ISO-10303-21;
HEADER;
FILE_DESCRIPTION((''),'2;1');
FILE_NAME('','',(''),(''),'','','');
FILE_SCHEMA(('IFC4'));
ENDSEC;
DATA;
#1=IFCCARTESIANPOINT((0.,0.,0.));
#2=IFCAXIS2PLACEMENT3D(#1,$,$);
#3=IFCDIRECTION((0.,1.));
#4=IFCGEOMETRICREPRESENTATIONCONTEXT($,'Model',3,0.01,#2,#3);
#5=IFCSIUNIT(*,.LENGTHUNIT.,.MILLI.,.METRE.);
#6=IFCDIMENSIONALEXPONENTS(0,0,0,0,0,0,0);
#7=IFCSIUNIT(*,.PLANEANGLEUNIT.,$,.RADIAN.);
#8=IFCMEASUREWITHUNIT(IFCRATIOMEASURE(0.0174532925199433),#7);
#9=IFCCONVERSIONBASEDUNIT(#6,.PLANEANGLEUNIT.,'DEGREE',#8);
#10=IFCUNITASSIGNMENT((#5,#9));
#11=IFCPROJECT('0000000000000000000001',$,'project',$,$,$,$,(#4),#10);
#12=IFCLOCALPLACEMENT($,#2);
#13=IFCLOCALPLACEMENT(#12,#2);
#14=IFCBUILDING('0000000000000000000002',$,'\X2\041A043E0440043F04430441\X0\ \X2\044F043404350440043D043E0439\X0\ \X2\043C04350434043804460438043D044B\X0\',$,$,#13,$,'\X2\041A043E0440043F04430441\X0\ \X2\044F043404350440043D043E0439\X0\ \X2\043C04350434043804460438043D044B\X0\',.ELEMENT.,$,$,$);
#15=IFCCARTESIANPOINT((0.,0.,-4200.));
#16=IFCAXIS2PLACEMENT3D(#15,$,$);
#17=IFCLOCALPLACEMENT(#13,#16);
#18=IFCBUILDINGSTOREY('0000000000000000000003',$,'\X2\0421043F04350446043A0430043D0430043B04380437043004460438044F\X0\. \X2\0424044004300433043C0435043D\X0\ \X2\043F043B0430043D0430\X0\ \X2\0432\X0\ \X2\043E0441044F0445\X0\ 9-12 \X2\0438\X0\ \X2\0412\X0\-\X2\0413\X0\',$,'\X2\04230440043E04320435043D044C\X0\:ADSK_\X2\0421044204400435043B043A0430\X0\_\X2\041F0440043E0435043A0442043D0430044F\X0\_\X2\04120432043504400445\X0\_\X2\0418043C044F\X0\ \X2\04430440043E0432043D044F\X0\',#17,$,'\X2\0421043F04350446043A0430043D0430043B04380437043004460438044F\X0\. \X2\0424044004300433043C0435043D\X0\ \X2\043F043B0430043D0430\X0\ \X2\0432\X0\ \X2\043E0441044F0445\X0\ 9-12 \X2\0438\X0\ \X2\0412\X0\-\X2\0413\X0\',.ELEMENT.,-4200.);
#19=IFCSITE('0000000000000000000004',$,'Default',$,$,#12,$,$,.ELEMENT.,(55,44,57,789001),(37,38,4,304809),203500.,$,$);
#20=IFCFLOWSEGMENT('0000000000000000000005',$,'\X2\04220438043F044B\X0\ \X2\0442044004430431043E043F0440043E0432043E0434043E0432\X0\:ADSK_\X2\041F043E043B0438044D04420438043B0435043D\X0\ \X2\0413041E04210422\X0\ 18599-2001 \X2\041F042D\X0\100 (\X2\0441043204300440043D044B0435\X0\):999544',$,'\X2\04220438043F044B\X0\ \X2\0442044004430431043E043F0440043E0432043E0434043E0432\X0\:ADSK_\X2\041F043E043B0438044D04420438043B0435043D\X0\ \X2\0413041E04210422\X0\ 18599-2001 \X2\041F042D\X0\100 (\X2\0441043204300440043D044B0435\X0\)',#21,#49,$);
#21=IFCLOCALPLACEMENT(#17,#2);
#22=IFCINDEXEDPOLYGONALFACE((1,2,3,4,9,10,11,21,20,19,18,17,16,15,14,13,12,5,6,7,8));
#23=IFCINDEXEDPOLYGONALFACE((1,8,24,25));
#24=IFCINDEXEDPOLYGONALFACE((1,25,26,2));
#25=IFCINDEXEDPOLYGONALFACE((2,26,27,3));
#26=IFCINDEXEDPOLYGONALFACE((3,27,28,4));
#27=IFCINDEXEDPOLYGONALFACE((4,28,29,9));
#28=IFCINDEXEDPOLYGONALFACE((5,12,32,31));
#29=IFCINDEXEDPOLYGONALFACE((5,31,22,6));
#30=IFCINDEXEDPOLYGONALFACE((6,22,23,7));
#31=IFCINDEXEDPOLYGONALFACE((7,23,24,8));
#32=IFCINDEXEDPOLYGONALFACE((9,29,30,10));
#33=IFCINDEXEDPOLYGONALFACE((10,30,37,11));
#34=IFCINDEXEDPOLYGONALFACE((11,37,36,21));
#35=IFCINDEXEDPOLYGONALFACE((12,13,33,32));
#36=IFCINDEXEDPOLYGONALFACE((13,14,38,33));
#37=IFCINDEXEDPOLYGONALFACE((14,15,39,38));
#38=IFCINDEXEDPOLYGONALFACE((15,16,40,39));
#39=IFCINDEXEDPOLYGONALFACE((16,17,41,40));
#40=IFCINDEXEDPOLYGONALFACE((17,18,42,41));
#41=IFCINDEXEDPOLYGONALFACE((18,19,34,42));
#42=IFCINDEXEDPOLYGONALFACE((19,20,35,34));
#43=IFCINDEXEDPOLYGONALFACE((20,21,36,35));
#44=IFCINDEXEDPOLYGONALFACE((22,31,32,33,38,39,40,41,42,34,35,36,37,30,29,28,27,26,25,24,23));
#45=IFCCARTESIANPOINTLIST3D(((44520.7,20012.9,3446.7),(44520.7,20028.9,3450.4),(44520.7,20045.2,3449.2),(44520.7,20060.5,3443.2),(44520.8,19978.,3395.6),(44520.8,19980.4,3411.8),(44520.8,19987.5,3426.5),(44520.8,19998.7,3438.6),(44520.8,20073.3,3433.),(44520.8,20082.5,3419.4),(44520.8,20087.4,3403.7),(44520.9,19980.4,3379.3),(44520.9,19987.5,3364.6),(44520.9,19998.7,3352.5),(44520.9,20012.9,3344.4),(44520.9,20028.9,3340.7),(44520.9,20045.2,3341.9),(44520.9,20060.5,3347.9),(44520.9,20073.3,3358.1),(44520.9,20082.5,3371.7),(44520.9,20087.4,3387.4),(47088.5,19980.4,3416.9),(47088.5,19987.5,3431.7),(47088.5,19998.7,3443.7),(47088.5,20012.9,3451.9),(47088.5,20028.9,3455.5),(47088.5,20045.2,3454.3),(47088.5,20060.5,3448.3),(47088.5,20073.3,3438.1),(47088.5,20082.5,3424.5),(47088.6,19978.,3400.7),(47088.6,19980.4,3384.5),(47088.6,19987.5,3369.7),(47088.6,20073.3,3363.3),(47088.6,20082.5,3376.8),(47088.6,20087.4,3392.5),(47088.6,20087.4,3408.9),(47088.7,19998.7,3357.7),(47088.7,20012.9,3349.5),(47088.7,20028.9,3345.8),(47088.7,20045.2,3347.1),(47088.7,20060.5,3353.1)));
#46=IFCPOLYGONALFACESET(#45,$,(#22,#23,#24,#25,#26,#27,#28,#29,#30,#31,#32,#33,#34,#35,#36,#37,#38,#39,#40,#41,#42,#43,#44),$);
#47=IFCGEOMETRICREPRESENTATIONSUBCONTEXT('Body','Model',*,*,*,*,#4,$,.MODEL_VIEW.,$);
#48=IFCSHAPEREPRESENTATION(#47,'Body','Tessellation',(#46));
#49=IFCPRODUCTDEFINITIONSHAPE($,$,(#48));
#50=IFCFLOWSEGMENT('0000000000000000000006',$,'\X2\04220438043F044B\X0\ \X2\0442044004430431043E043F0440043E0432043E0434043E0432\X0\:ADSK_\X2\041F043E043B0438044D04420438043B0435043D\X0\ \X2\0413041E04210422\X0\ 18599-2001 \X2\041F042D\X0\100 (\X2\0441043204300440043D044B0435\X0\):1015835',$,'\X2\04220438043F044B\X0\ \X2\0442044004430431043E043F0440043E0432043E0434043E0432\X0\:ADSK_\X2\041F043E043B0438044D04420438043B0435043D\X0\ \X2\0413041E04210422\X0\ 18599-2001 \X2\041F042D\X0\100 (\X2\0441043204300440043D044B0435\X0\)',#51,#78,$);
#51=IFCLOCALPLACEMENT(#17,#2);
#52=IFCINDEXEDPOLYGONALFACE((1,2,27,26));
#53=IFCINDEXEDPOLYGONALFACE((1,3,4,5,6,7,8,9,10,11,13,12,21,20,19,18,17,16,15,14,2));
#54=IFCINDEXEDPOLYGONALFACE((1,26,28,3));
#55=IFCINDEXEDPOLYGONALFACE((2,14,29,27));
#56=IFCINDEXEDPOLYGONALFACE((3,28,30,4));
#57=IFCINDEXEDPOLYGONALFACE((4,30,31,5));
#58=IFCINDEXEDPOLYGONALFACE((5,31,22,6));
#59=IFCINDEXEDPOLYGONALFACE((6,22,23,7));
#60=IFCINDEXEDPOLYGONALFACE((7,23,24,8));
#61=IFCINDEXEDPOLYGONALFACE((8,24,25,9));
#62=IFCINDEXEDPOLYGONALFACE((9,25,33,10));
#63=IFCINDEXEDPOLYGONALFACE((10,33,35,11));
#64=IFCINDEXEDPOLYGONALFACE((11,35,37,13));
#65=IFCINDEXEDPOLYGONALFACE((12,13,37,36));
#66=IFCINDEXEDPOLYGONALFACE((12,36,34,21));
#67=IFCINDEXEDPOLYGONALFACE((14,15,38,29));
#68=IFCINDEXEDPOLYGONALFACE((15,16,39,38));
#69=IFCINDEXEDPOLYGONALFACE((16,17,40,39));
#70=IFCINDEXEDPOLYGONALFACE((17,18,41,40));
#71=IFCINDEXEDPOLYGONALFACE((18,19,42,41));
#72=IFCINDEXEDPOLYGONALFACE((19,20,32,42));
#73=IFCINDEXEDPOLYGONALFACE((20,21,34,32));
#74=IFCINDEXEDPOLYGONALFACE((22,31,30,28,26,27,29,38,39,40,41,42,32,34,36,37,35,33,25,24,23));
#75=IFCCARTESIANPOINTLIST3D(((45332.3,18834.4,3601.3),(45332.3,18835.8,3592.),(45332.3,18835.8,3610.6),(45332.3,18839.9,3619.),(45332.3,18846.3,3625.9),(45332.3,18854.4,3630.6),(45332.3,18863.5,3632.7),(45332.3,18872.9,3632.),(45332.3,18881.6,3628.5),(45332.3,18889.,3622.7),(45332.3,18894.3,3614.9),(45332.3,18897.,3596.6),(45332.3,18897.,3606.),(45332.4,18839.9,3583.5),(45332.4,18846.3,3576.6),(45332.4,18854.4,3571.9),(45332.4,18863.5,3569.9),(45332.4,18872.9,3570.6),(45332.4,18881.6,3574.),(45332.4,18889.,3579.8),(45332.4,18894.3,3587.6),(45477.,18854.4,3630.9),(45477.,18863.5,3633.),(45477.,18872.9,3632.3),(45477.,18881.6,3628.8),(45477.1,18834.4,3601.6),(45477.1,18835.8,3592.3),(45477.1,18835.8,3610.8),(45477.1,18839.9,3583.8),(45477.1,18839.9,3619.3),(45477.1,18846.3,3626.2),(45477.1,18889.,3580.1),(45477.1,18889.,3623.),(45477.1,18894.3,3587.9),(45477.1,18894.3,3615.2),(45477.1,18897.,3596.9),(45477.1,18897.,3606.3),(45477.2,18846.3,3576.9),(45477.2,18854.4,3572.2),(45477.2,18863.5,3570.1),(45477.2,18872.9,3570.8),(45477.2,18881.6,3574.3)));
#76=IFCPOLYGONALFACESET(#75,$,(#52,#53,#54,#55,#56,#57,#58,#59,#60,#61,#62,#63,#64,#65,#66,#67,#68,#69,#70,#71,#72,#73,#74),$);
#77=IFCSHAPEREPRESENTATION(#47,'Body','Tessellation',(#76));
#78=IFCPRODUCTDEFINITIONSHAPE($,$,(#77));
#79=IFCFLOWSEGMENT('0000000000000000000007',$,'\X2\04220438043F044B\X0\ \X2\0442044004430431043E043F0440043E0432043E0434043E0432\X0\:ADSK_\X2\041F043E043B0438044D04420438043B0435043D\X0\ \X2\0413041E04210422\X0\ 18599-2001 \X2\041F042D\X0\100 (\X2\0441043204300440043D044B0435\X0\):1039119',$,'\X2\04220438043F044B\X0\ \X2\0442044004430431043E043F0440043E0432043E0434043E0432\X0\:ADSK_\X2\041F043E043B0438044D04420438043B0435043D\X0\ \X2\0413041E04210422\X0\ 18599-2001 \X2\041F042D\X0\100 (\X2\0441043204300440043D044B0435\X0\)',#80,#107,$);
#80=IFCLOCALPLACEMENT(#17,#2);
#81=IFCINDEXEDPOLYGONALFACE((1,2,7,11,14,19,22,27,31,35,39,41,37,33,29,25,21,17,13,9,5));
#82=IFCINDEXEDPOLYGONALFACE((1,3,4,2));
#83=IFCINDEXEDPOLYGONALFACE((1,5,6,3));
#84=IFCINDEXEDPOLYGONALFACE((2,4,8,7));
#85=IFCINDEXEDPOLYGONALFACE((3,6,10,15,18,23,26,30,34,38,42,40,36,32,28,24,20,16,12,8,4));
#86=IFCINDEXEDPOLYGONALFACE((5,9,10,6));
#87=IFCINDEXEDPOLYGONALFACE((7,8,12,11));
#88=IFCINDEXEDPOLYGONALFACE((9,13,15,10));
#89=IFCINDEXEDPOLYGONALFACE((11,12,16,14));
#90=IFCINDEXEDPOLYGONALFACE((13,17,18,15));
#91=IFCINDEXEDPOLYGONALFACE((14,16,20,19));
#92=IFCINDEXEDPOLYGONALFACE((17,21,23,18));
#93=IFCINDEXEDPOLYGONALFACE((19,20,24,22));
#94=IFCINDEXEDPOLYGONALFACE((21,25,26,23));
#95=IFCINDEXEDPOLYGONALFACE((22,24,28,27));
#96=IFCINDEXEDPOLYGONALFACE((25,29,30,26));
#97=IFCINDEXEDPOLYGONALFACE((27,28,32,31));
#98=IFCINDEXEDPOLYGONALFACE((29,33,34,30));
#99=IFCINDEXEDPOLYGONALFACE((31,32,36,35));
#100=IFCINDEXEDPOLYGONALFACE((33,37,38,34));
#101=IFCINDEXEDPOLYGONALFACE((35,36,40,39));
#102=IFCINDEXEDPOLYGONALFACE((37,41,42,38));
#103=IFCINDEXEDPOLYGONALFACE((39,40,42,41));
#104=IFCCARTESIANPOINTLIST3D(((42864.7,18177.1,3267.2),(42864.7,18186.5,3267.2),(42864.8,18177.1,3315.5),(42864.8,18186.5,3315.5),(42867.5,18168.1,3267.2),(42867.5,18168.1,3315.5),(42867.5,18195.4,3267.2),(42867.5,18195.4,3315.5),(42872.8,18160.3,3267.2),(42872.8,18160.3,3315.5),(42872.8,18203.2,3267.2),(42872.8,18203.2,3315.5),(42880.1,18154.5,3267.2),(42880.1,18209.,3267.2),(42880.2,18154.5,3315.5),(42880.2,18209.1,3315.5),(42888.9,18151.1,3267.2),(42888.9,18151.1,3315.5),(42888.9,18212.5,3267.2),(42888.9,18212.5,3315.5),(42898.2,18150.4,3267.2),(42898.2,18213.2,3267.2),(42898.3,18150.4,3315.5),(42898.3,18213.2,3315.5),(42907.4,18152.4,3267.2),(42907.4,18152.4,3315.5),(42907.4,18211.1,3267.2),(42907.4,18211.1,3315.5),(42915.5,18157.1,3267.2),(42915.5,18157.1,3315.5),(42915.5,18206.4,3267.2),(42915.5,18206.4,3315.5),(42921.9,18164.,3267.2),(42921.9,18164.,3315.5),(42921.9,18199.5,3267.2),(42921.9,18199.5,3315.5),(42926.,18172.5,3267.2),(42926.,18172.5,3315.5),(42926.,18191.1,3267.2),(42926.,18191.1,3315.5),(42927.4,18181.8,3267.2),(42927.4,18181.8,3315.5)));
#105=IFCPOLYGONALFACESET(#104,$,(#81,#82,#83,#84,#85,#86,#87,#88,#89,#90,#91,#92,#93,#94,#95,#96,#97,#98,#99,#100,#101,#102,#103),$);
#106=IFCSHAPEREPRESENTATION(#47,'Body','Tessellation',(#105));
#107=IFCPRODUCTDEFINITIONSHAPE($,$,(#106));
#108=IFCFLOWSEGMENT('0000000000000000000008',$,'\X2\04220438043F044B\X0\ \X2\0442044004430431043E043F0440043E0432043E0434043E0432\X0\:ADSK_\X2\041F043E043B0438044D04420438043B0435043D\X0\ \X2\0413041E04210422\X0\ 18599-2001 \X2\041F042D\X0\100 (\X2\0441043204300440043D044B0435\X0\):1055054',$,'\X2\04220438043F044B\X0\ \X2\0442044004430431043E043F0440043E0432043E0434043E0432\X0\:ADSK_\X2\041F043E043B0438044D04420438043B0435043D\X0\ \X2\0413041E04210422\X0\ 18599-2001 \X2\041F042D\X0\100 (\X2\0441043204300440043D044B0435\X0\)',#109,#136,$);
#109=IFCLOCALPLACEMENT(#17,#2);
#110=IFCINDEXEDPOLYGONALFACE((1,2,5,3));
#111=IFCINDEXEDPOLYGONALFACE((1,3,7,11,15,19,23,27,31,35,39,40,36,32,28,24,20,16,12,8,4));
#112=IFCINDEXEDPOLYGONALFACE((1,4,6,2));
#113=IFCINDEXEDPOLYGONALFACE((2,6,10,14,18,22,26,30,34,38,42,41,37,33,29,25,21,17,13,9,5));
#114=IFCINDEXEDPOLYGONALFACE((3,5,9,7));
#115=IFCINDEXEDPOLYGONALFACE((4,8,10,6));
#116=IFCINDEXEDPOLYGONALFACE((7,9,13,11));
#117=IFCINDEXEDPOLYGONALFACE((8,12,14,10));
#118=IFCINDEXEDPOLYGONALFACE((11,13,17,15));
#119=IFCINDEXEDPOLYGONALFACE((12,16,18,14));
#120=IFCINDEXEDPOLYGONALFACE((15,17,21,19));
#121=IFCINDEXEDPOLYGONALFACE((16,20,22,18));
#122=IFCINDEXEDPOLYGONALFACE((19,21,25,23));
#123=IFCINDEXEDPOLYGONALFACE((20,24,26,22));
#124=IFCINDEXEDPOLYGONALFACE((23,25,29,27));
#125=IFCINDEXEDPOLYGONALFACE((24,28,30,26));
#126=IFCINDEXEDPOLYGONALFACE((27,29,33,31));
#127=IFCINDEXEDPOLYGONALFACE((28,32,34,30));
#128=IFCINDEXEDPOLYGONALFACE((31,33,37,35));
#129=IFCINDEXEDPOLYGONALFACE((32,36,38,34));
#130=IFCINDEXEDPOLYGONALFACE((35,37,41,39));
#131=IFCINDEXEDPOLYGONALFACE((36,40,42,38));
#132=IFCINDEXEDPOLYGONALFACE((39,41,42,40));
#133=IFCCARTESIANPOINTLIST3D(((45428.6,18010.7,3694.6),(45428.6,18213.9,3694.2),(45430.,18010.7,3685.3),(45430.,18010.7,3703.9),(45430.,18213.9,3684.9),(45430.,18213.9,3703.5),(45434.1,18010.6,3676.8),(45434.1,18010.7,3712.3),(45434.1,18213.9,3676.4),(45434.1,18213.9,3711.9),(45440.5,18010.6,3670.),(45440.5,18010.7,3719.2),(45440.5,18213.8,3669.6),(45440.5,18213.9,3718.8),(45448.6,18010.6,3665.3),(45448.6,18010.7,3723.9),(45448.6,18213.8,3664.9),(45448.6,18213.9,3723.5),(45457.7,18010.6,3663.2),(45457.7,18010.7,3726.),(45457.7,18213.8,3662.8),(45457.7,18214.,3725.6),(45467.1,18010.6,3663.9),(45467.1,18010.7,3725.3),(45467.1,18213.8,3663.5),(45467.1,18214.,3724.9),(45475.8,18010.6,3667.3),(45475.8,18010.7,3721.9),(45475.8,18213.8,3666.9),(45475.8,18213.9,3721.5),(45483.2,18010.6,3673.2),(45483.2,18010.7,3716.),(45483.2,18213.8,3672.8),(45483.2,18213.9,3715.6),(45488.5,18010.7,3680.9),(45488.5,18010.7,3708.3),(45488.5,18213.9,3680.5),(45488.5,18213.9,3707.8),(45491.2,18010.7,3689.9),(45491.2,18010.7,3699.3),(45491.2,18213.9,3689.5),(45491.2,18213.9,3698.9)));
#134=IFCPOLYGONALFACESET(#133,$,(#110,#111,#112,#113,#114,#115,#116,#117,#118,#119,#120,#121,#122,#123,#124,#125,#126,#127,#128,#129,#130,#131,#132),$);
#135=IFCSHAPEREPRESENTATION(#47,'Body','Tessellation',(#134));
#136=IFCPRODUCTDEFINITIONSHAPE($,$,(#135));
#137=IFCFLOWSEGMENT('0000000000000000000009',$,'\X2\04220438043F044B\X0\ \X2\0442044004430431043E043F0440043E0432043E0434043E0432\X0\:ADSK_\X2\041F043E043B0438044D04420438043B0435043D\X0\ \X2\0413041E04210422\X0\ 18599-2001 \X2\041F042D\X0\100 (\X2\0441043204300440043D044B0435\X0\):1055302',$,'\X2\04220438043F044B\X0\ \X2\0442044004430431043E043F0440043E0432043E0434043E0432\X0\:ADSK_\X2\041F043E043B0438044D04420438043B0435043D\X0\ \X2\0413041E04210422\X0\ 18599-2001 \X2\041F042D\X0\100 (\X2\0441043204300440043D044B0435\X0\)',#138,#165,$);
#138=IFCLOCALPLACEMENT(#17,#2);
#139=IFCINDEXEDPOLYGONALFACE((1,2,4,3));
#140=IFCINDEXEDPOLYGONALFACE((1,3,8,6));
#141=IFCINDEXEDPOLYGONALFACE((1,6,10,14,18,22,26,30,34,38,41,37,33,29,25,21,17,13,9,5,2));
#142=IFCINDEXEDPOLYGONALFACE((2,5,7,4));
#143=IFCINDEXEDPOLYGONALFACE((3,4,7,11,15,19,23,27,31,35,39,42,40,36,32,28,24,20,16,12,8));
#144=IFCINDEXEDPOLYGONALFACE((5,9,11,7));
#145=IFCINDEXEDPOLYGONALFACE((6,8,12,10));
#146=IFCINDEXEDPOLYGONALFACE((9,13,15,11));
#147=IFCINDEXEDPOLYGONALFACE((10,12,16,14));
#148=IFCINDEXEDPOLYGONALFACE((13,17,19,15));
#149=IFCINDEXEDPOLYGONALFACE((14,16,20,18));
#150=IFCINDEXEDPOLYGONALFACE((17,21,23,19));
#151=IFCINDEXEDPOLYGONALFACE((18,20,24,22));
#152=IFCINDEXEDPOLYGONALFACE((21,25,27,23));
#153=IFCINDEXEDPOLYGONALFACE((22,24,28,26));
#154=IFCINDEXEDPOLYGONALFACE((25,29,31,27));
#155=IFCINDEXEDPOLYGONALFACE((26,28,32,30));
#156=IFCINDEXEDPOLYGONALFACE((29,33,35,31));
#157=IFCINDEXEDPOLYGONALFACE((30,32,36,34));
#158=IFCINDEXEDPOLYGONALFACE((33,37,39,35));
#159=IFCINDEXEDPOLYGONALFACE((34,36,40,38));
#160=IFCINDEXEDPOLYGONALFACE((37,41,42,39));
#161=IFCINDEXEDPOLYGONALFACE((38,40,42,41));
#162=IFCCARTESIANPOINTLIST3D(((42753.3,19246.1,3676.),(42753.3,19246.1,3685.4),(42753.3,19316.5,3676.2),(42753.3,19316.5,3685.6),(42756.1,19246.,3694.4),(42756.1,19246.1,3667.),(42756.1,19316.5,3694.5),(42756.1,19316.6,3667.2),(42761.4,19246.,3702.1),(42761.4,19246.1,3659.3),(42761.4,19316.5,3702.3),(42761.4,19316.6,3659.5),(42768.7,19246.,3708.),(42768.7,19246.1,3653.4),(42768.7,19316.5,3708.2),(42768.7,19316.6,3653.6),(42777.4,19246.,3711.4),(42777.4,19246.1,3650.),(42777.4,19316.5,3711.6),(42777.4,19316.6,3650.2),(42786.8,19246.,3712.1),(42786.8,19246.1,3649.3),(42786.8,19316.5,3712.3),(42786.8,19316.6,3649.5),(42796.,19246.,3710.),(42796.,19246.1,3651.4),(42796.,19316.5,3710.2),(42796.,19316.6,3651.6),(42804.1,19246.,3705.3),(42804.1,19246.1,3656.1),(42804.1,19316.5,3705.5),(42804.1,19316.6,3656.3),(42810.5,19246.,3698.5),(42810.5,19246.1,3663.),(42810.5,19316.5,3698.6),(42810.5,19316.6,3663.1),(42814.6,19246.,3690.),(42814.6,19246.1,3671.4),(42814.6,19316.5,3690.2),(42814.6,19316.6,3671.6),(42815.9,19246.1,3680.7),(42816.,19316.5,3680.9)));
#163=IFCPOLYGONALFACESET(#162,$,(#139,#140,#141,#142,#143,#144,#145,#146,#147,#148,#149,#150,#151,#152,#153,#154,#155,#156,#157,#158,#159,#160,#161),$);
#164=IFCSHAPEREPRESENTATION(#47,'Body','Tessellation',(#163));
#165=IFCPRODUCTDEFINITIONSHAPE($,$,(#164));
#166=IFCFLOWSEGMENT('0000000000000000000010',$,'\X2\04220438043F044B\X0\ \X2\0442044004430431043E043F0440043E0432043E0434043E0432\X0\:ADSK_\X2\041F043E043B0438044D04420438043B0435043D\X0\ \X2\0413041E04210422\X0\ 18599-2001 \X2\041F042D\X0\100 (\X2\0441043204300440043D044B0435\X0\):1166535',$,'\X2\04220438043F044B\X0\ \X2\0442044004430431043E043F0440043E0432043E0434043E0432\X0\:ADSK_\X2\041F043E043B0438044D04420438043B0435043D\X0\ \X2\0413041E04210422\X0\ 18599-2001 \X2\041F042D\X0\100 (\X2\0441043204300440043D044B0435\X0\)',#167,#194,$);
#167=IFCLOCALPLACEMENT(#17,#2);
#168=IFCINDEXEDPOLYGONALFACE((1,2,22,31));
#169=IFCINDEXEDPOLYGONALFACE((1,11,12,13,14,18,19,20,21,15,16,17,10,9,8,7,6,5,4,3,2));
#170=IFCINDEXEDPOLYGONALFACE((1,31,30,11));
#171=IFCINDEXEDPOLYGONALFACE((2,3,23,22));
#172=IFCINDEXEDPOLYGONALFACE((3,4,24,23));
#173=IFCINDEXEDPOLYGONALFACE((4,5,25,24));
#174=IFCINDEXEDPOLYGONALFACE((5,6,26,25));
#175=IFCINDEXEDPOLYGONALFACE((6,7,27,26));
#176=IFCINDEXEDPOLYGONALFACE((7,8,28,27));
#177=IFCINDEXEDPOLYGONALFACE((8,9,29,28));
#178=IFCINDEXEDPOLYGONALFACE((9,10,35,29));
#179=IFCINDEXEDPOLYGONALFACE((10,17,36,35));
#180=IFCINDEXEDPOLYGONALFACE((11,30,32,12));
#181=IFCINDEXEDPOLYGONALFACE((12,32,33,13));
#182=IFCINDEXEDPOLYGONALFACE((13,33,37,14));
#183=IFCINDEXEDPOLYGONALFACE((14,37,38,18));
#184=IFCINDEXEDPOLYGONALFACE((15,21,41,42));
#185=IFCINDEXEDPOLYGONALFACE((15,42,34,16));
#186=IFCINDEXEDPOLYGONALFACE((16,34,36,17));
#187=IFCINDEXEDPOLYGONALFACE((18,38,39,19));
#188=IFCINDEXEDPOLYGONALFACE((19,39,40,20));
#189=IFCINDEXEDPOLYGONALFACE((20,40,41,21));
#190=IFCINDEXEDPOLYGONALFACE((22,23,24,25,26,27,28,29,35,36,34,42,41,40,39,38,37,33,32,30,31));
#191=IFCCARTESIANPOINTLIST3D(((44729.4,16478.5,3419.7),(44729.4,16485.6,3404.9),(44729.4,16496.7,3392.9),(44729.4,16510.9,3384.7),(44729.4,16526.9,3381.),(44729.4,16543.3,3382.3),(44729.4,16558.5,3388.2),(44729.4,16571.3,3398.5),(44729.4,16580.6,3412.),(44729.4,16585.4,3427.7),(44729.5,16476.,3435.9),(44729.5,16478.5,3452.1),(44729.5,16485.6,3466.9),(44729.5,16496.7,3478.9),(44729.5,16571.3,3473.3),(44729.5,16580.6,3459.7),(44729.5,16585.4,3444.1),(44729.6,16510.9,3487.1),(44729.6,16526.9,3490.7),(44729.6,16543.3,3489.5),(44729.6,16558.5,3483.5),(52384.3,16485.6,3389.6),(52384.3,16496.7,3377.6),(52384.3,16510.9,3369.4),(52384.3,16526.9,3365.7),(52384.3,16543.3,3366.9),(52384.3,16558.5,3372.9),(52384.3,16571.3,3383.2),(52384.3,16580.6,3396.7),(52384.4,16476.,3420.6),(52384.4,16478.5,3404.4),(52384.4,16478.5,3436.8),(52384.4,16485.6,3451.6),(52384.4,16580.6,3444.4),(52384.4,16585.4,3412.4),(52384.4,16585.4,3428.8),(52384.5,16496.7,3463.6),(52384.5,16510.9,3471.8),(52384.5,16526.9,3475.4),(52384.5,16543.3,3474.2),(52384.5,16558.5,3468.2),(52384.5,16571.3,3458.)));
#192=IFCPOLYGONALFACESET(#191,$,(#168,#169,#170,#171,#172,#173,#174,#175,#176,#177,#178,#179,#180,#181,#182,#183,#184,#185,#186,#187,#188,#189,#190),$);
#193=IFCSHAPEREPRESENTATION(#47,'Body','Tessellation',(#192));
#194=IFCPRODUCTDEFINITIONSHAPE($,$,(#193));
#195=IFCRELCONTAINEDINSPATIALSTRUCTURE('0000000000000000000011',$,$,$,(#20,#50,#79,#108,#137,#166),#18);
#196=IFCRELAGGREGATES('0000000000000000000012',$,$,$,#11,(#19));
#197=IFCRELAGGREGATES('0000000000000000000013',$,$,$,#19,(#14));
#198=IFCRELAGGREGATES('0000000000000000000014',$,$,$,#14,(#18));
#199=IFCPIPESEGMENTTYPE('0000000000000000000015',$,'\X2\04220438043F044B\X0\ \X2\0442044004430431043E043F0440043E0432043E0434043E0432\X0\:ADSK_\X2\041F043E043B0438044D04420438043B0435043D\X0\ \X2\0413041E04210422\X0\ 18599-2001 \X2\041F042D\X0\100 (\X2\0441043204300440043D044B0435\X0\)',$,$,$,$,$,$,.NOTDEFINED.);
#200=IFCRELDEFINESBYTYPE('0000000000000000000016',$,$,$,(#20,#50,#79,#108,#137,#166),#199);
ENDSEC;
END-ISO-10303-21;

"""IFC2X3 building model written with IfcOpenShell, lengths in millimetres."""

from ifc_helpers import new_model, entity, si_unit, converted_unit, direction, frame, origin, origin_2d_with_axis, place, context, subcontext, project, spatial, circle, extrude, type_object, element, save


model = new_model("IFC2X3")

# Units and contexts
model_context = context("Model", 3, precision=0.01, world=origin(), true_north=direction((0.0, 1.0)))
body_context = subcontext(model_context, "Body", "Model", "MODEL_VIEW")
ifc_project = project(units=[si_unit("LENGTHUNIT", "METRE", prefix="MILLI"), converted_unit("PLANEANGLEUNIT", "DEGREE", entity("IfcRatioMeasure", 0.0174532925199433), si_unit("PLANEANGLEUNIT", "RADIAN"), dimensions=[0, 0, 0, 0, 0, 0, 0])], contexts=[model_context])

# Site, building, storey
site_placement = place(None, origin())
site = spatial("IfcSite", under=ifc_project, at=site_placement, Name="Default", CompositionType="ELEMENT", RefLatitude=(55, 44, 57, 789001), RefLongitude=(37, 38, 4, 304809), RefElevation=203500.0)
building_placement = place(site_placement, origin())
building = spatial("IfcBuilding", under=site, at=building_placement, Name="Корпус ядерной медицины", LongName="Корпус ядерной медицины", CompositionType="ELEMENT")
storey_placement = place(building_placement, frame((0.0, 0.0, -4200.0)))
storey = spatial("IfcBuildingStorey", under=building, at=storey_placement, Name="Спецканализация. Фрагмен плана в осях 9-12 и В-Г", ObjectType="Уровень:ADSK_Стрелка_Проектная_Вверх_Имя уровня", LongName="Спецканализация. Фрагмен плана в осях 9-12 и В-Г", CompositionType="ELEMENT", Elevation=-4200.0)

# Flow segments
pipe_segment_type = type_object("IfcPipeSegmentType", Name="Типы трубопроводов:ADSK_Полиэтилен ГОСТ 18599-2001 ПЭ100 (сварные)", PredefinedType="NOTDEFINED")
flow_segment_1_placement = place(storey_placement, frame((44520.7, 19976.4, 3338.9)))
element("IfcFlowSegment", 1, at=flow_segment_1_placement, inside=storey, type_object=pipe_segment_type, Name="Типы трубопроводов:ADSK_Полиэтилен ГОСТ 18599-2001 ПЭ100 (сварные):999544", ObjectType="Типы трубопроводов:ADSK_Полиэтилен ГОСТ 18599-2001 ПЭ100 (сварные)", context=body_context, shape_type="SweptSolid", body=[
    extrude(circle(Radius=55.0, at=origin_2d_with_axis()), frame((0.1, 56.6, 56.6), z_axis=(0.999998, 0.0, 0.002), x_axis=(0.0, -1.0, 0.0)), (0.0, 0.0, 1.0), 2567.7),
])
flow_segment_2_placement = place(storey_placement, frame((45332.3, 18832.8, 3568.2)))
element("IfcFlowSegment", 2, at=flow_segment_2_placement, inside=storey, type_object=pipe_segment_type, Name="Типы трубопроводов:ADSK_Полиэтилен ГОСТ 18599-2001 ПЭ100 (сварные):1015835", ObjectType="Типы трубопроводов:ADSK_Полиэтилен ГОСТ 18599-2001 ПЭ100 (сварные)", context=body_context, shape_type="SweptSolid", body=[
    extrude(circle(Radius=31.5, at=origin_2d_with_axis()), frame((0.1, 33.1, 33.1), z_axis=(0.999998, 0.0, 0.002), x_axis=(0.0, -1.0, 0.0)), (0.0, 0.0, 1.0), 144.8),
])
flow_segment_3_placement = place(storey_placement, frame((42862.8, 18148.7, 3267.2)))
element("IfcFlowSegment", 3, at=flow_segment_3_placement, inside=storey, type_object=pipe_segment_type, Name="Типы трубопроводов:ADSK_Полиэтилен ГОСТ 18599-2001 ПЭ100 (сварные):1039119", ObjectType="Типы трубопроводов:ADSK_Полиэтилен ГОСТ 18599-2001 ПЭ100 (сварные)", context=body_context, shape_type="SweptSolid", body=[
    extrude(circle(Radius=31.5, at=origin_2d_with_axis()), frame((33.1, 33.1, 0.0), z_axis=(0.000235, 0.00001, 1.0), x_axis=(1.0, 0.0, -0.000235)), (0.0, 0.0, 1.0), 48.3),
])
flow_segment_4_placement = place(storey_placement, frame((45427.0, 18010.6, 3661.1)))
element("IfcFlowSegment", 4, at=flow_segment_4_placement, inside=storey, type_object=pipe_segment_type, Name="Типы трубопроводов:ADSK_Полиэтилен ГОСТ 18599-2001 ПЭ100 (сварные):1055054", ObjectType="Типы трубопроводов:ADSK_Полиэтилен ГОСТ 18599-2001 ПЭ100 (сварные)", context=body_context, shape_type="SweptSolid", body=[
    extrude(circle(Radius=31.5, at=origin_2d_with_axis()), frame((33.1, 203.3, 33.1), z_axis=(0.0, -0.999998, 0.002), x_axis=(-1.0, 0.0, 0.0)), (0.0, 0.0, 1.0), 203.2),
])
flow_segment_5_placement = place(storey_placement, frame((42751.3, 19246.0, 3647.6)))
element("IfcFlowSegment", 5, at=flow_segment_5_placement, inside=storey, type_object=pipe_segment_type, Name="Типы трубопроводов:ADSK_Полиэтилен ГОСТ 18599-2001 ПЭ100 (сварные):1055302", ObjectType="Типы трубопроводов:ADSK_Полиэтилен ГОСТ 18599-2001 ПЭ100 (сварные)", context=body_context, shape_type="SweptSolid", body=[
    extrude(circle(Radius=31.5, at=origin_2d_with_axis()), frame((33.1, 0.1, 33.1), z_axis=(0.000001, 0.999997, 0.002426), x_axis=(1.0, -0.000001, 0.0)), (0.0, 0.0, 1.0), 70.5),
])
flow_segment_6_placement = place(storey_placement, frame((44729.3, 16474.4, 3364.0)))
element("IfcFlowSegment", 6, at=flow_segment_6_placement, inside=storey, type_object=pipe_segment_type, Name="Типы трубопроводов:ADSK_Полиэтилен ГОСТ 18599-2001 ПЭ100 (сварные):1166535", ObjectType="Типы трубопроводов:ADSK_Полиэтилен ГОСТ 18599-2001 ПЭ100 (сварные)", context=body_context, shape_type="SweptSolid", body=[
    extrude(circle(Radius=55.0, at=origin_2d_with_axis()), frame((0.1, 56.6, 71.9), z_axis=(0.999998, 0.0, -0.002), x_axis=(0.0, -1.0, 0.0)), (0.0, 0.0, 1.0), 7654.9),
])

save(model, "model.ifc")
